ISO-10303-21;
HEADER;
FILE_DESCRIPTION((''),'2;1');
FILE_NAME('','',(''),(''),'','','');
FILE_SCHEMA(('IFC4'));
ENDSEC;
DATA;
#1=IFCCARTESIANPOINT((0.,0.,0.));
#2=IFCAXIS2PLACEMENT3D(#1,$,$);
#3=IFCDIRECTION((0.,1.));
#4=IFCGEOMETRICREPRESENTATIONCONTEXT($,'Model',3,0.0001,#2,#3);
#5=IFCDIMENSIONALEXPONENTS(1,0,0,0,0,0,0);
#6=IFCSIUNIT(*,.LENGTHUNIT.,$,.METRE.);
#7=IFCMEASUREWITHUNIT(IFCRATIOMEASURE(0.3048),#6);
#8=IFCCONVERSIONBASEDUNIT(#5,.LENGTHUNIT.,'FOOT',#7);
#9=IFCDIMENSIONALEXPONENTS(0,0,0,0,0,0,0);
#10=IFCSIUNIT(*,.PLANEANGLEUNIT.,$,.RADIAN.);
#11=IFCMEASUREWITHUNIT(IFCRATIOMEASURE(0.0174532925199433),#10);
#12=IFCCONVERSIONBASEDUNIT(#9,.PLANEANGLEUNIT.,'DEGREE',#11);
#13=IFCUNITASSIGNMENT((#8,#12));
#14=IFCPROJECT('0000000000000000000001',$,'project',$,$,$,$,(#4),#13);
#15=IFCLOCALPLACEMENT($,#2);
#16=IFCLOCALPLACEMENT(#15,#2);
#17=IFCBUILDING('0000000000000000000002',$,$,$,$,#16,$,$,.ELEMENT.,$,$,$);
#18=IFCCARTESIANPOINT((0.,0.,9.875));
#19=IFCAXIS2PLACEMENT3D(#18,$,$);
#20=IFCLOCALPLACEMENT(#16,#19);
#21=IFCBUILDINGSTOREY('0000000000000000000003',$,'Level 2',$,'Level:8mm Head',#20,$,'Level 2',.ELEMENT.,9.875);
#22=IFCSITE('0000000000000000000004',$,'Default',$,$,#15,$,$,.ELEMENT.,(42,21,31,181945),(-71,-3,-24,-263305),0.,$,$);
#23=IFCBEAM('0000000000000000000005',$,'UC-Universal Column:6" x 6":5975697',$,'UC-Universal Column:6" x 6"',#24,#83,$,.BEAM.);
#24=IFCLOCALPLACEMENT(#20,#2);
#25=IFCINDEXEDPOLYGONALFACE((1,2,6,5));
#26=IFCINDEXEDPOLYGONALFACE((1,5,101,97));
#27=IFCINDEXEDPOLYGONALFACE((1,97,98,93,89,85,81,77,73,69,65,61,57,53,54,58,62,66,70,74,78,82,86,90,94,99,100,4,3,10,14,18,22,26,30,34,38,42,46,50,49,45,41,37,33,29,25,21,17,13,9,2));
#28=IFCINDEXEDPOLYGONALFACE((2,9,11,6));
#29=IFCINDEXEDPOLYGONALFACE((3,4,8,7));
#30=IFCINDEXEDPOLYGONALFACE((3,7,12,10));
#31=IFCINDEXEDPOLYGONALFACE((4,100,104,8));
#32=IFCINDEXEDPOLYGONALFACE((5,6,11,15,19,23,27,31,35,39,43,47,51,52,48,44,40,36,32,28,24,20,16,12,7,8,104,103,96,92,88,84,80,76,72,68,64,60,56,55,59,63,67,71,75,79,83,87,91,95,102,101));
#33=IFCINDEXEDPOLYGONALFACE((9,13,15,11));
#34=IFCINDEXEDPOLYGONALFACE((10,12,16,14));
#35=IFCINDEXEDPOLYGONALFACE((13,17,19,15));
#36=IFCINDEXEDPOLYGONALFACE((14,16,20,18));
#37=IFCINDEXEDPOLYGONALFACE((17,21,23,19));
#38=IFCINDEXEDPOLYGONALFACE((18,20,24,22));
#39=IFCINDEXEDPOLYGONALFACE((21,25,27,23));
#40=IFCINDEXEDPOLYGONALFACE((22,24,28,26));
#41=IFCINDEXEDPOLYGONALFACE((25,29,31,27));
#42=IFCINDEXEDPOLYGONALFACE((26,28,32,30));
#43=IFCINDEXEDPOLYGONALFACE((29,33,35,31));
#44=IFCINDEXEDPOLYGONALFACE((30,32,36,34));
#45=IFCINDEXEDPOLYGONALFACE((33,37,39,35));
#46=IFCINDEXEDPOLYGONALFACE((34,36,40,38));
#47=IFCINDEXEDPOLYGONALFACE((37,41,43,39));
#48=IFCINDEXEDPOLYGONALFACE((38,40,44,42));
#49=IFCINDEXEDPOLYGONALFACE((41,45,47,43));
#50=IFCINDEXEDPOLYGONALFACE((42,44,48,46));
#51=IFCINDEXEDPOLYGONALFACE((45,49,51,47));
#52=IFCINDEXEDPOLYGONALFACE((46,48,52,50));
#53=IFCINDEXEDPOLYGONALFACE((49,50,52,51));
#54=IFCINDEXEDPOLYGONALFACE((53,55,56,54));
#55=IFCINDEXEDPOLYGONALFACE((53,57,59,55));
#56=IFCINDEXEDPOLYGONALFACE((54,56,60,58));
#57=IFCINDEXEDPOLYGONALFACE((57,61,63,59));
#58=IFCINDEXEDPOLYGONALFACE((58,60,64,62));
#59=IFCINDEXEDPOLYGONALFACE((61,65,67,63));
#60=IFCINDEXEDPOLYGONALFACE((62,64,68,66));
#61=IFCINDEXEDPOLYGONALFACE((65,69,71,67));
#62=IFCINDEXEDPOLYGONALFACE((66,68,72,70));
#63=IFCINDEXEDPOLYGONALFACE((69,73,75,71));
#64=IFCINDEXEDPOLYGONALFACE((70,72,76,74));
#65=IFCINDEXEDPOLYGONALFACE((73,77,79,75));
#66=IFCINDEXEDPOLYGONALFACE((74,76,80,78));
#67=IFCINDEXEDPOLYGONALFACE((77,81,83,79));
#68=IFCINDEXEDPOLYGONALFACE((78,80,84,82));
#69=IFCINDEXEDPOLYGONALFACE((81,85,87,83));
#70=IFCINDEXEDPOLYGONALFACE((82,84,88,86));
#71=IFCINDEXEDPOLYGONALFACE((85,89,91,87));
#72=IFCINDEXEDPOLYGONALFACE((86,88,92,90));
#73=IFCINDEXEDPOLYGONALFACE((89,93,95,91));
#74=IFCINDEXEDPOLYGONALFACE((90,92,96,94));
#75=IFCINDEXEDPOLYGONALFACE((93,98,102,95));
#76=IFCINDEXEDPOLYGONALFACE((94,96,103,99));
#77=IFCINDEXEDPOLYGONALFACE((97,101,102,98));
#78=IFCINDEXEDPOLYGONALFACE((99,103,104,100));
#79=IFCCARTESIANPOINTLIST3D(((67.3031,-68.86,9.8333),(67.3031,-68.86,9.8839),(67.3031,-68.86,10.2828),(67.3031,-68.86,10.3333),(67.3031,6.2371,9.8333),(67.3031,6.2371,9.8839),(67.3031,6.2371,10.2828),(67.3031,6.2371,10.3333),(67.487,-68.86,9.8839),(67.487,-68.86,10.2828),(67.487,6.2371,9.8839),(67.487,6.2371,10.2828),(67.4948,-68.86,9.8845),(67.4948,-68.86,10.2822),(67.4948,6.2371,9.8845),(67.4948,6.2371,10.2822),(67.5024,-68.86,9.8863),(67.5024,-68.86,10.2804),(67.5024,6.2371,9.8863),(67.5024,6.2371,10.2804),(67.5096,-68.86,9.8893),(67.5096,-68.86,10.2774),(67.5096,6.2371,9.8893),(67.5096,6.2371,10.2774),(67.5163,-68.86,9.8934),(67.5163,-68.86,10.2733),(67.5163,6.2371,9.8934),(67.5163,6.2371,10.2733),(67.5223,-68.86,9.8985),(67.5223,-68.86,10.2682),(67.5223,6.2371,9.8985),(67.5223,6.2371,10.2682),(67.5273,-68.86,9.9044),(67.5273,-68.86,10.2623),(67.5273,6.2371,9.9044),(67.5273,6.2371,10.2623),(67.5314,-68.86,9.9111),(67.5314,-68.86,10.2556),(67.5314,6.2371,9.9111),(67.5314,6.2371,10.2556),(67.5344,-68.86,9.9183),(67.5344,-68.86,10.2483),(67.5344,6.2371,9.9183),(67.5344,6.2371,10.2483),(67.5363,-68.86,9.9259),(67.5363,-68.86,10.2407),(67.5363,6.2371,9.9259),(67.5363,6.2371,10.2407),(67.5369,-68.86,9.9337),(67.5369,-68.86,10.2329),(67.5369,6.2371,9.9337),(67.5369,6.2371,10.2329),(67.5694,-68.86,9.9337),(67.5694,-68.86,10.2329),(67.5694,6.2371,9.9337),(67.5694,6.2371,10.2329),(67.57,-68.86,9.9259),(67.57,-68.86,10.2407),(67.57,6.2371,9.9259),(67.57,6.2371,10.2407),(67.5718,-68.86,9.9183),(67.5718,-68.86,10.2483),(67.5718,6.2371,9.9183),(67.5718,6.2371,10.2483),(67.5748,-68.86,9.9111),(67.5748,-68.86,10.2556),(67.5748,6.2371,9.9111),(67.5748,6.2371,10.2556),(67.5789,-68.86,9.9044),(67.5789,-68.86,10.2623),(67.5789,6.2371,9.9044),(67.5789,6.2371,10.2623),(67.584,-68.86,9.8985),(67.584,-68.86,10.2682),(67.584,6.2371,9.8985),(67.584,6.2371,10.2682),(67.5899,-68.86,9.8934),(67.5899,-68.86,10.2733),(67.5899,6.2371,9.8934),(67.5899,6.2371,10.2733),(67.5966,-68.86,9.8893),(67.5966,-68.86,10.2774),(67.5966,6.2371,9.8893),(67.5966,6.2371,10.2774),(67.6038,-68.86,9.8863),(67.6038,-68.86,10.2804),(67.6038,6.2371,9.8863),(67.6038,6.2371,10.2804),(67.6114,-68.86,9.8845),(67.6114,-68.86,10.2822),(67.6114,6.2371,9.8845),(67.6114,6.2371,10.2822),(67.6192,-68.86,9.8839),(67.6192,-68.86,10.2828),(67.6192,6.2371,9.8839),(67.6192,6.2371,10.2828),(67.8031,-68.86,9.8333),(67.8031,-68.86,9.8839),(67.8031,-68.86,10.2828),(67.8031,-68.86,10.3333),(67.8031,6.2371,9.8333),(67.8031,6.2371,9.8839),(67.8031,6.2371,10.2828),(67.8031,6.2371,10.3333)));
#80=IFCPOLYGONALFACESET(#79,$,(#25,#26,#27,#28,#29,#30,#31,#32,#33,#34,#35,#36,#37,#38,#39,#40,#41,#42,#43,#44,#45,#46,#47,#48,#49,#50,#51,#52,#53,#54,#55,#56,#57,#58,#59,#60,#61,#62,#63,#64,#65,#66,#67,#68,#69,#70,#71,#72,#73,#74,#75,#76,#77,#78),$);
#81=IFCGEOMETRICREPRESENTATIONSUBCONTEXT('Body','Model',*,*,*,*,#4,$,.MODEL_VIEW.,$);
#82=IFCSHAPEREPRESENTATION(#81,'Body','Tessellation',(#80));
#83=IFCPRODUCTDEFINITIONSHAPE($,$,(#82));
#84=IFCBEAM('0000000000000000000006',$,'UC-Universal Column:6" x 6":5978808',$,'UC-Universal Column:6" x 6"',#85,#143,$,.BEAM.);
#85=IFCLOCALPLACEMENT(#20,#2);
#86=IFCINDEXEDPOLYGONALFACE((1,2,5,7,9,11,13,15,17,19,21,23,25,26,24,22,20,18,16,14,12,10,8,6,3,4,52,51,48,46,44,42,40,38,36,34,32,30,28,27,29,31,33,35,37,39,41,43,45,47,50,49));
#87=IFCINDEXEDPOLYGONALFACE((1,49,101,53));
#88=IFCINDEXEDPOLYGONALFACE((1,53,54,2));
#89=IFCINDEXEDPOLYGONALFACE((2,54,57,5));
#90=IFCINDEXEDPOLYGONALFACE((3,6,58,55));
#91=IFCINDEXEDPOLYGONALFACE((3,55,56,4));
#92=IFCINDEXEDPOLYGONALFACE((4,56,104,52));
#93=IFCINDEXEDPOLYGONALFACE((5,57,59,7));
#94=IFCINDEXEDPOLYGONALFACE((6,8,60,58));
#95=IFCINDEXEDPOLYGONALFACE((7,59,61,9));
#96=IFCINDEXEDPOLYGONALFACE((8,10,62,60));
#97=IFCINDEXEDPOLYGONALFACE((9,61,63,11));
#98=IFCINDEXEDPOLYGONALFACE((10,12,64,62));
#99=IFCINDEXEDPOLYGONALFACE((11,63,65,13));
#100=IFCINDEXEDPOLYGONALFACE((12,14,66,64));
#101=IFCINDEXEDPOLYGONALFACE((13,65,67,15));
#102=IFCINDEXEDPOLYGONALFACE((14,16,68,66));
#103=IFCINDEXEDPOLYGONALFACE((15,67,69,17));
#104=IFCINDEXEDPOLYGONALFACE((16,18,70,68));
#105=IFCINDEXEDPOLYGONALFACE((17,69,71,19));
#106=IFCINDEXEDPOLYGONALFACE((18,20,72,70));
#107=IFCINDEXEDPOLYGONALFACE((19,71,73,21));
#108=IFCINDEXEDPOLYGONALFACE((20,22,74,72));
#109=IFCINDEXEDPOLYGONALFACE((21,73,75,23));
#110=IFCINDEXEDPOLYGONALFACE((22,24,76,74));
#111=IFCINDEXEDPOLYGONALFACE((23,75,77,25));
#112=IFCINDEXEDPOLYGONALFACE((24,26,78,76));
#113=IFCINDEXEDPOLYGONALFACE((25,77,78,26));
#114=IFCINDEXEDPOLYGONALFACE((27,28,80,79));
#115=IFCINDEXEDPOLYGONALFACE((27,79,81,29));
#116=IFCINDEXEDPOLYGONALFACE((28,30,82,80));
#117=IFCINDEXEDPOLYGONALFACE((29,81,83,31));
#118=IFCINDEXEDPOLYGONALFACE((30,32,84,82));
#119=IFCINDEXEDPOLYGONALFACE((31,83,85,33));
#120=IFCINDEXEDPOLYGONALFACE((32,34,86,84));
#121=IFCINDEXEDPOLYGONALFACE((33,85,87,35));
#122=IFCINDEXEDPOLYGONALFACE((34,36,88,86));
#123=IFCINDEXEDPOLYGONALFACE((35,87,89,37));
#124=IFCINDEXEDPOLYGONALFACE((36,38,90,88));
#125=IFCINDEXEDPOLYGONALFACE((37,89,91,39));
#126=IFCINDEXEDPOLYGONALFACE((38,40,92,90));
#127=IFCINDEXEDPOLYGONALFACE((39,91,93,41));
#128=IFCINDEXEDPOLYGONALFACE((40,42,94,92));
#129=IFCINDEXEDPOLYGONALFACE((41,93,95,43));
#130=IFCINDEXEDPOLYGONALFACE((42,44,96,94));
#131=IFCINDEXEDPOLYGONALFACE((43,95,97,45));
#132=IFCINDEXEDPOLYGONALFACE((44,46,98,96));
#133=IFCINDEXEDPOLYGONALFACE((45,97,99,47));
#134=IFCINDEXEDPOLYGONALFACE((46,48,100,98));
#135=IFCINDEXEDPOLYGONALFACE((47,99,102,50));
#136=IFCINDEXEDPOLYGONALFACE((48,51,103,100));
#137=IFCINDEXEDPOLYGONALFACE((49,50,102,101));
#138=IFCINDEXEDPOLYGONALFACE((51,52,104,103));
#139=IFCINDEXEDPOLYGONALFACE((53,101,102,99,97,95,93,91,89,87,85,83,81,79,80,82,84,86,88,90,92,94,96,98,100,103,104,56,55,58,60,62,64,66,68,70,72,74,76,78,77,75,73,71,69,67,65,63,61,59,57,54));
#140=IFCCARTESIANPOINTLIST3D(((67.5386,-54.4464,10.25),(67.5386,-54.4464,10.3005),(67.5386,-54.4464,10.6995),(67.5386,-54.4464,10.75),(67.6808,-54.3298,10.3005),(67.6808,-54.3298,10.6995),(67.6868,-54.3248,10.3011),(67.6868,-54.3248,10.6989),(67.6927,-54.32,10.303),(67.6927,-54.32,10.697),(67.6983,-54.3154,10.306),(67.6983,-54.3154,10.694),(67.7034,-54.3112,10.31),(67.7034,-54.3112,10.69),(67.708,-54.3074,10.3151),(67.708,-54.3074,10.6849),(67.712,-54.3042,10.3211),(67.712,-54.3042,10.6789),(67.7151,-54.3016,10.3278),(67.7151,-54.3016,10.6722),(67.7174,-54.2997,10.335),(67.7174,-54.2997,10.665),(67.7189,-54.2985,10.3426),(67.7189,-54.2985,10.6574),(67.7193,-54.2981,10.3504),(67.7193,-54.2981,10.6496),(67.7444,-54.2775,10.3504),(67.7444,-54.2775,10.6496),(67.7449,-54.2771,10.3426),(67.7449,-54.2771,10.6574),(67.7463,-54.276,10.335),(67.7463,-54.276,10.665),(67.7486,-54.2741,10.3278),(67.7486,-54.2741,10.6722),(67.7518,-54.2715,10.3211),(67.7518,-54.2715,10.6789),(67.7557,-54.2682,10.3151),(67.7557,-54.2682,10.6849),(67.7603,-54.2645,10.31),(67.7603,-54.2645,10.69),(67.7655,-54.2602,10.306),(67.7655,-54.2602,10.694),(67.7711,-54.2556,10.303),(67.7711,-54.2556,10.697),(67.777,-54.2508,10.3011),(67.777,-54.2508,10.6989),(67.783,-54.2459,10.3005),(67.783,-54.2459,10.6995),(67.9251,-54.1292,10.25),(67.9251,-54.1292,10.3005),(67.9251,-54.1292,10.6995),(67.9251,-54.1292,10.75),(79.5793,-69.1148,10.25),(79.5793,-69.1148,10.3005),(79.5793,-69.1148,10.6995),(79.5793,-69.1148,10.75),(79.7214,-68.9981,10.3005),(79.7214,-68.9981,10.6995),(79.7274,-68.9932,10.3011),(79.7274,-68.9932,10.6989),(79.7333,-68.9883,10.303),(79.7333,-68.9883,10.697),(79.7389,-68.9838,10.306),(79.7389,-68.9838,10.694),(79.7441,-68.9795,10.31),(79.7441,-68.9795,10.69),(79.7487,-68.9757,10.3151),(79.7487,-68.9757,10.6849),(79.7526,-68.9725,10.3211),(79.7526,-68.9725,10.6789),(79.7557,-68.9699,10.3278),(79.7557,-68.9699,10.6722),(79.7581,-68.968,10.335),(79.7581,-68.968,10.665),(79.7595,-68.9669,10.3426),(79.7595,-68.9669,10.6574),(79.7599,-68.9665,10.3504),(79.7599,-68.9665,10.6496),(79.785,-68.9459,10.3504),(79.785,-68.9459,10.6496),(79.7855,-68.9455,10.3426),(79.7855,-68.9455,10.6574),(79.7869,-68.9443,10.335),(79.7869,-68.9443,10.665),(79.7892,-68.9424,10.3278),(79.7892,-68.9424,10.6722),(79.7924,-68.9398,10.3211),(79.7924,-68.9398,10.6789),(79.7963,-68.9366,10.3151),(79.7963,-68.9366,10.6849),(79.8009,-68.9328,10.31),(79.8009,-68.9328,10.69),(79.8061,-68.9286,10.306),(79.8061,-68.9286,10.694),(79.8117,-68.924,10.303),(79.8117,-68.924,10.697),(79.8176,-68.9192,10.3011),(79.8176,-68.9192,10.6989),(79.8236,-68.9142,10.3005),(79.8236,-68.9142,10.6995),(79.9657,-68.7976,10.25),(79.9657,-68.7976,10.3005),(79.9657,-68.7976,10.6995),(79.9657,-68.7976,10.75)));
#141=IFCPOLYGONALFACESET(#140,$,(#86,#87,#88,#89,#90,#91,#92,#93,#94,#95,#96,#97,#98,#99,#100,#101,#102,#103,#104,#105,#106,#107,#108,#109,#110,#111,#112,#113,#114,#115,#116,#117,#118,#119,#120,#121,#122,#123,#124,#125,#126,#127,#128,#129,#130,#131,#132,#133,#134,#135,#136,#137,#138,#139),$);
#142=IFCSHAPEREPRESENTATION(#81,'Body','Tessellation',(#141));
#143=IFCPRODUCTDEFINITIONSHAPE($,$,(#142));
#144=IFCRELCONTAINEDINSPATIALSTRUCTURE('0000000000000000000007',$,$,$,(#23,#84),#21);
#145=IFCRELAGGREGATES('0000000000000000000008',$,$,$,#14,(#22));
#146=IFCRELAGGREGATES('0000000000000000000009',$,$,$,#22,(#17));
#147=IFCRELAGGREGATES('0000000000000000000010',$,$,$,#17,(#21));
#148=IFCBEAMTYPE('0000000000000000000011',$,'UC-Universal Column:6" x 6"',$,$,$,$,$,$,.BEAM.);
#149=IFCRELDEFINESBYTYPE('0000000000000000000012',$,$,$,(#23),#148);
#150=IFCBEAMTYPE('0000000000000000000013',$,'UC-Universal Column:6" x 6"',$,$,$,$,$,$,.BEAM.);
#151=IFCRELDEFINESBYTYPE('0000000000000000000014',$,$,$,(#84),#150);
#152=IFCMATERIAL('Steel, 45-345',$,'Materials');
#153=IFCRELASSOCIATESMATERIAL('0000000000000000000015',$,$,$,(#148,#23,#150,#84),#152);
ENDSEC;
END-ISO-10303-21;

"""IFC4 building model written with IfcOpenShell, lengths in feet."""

from ifc_helpers import new_model, entity, si_unit, converted_unit, direction, frame, origin, place, context, subcontext, project, spatial, indexed_curve, outline, extrude, source, transform, mapped, material, type_object, type_shapes, element, save


model = new_model("IFC4")

# Units and contexts
model_context = context("Model", 3, precision=0.0001, world=origin(), true_north=direction((0.0, 1.0)))
body_context = subcontext(model_context, "Body", "Model", "MODEL_VIEW")
ifc_project = project(units=[converted_unit("LENGTHUNIT", "FOOT", entity("IfcRatioMeasure", 0.3048), si_unit("LENGTHUNIT", "METRE"), dimensions=[1, 0, 0, 0, 0, 0, 0]), converted_unit("PLANEANGLEUNIT", "DEGREE", entity("IfcRatioMeasure", 0.0174532925199433), si_unit("PLANEANGLEUNIT", "RADIAN"), dimensions=[0, 0, 0, 0, 0, 0, 0])], contexts=[model_context])

# Site, building, storey
site_placement = place(None, origin())
site = spatial("IfcSite", under=ifc_project, at=site_placement, Name="Default", CompositionType="ELEMENT", RefLatitude=(42, 21, 31, 181945), RefLongitude=(-71, -3, -24, -263305), RefElevation=0.0)
building_placement = place(site_placement, origin())
building = spatial("IfcBuilding", under=site, at=building_placement, CompositionType="ELEMENT")
storey_placement = place(building_placement, frame((0.0, 0.0, 9.875)))
storey = spatial("IfcBuildingStorey", under=building, at=storey_placement, Name="Level 2", ObjectType="Level:8mm Head", LongName="Level 2", CompositionType="ELEMENT", Elevation=9.875)

# Beams
ifc_material_1 = material(Name="Steel, 45-345", Category="Materials")
beam_type_1 = type_object("IfcBeamType", Name="UC-Universal Column:6\" x 6\"", PredefinedType="BEAM", material=ifc_material_1)
shared_shape_1 = source(origin(), body_context, "Body", "SweptSolid", [
    extrude(outline(indexed_curve([(-0.25, -0.25), (-0.1995, -0.25), (-0.1995, -0.0661), (-0.1989, -0.0583), (-0.197, -0.0507), (-0.194, -0.0435), (-0.19, -0.0368), (-0.1849, -0.0308), (-0.1789, -0.0258), (-0.1722, -0.0217), (-0.165, -0.0187), (-0.1574, -0.0169), (-0.1496, -0.0162), (0.1496, -0.0162), (0.1574, -0.0169), (0.165, -0.0187), (0.1722, -0.0217), (0.1789, -0.0258), (0.1849, -0.0308), (0.19, -0.0368), (0.194, -0.0435), (0.197, -0.0507), (0.1989, -0.0583), (0.1995, -0.0661), (0.1995, -0.25), (0.25, -0.25), (0.25, 0.25), (0.1995, 0.25), (0.1995, 0.0661), (0.1989, 0.0583), (0.197, 0.0507), (0.194, 0.0435), (0.19, 0.0368), (0.1849, 0.0308), (0.1789, 0.0258), (0.1722, 0.0217), (0.165, 0.0187), (0.1574, 0.0169), (0.1496, 0.0162), (-0.1496, 0.0162), (-0.1574, 0.0169), (-0.165, 0.0187), (-0.1722, 0.0217), (-0.1789, 0.0258), (-0.1849, 0.0308), (-0.19, 0.0368), (-0.194, 0.0435), (-0.197, 0.0507), (-0.1989, 0.0583), (-0.1995, 0.0661), (-0.1995, 0.25), (-0.25, 0.25), (-0.25, -0.25)], self_intersect=False)), frame((-7.7826, 0.0, 0.0), z_axis=(1.0, 0.0, 0.0), x_axis=(0.0, 0.0, -1.0)), (0.0, 0.0, 1.0), 75.0972),
])
type_shapes(beam_type_1, [shared_shape_1])
beam_1_placement = place(storey_placement, frame((67.5531, -61.0774, 10.0833), z_axis=(0.0, 0.0, 1.0), x_axis=(0.0, 1.0, 0.0)))
element("IfcBeam", 1, at=beam_1_placement, inside=storey, type_object=beam_type_1, material=ifc_material_1, Name="UC-Universal Column:6\" x 6\":5975697", ObjectType="UC-Universal Column:6\" x 6\"", PredefinedType="BEAM", context=body_context, shape_type="MappedRepresentation", body=[
    mapped(shared_shape_1, transform((0.0, 0.0, 0.0), scale=1.0)),
])
beam_type_2 = type_object("IfcBeamType", Name="UC-Universal Column:6\" x 6\"", PredefinedType="BEAM", material=ifc_material_1)
shared_shape_2 = source(origin(), body_context, "Body", "SweptSolid", [
    extrude(outline(indexed_curve([(-0.25, -0.25), (-0.1995, -0.25), (-0.1995, -0.0661), (-0.1989, -0.0583), (-0.197, -0.0507), (-0.194, -0.0435), (-0.19, -0.0368), (-0.1849, -0.0308), (-0.1789, -0.0258), (-0.1722, -0.0217), (-0.165, -0.0187), (-0.1574, -0.0169), (-0.1496, -0.0162), (0.1496, -0.0162), (0.1574, -0.0169), (0.165, -0.0187), (0.1722, -0.0217), (0.1789, -0.0258), (0.1849, -0.0308), (0.19, -0.0368), (0.194, -0.0435), (0.197, -0.0507), (0.1989, -0.0583), (0.1995, -0.0661), (0.1995, -0.25), (0.25, -0.25), (0.25, 0.25), (0.1995, 0.25), (0.1995, 0.0661), (0.1989, 0.0583), (0.197, 0.0507), (0.194, 0.0435), (0.19, 0.0368), (0.1849, 0.0308), (0.1789, 0.0258), (0.1722, 0.0217), (0.165, 0.0187), (0.1574, 0.0169), (0.1496, 0.0162), (-0.1496, 0.0162), (-0.1574, 0.0169), (-0.165, 0.0187), (-0.1722, 0.0217), (-0.1789, 0.0258), (-0.1849, 0.0308), (-0.19, 0.0368), (-0.194, 0.0435), (-0.197, 0.0507), (-0.1989, 0.0583), (-0.1995, 0.0661), (-0.1995, 0.25), (-0.25, 0.25), (-0.25, -0.25)], self_intersect=False)), frame((-9.2456, 0.0, 0.0), z_axis=(1.0, 0.0, 0.0), x_axis=(0.0, 0.0, -1.0)), (0.0, 0.0, 1.0), 18.9773),
])
type_shapes(beam_type_2, [shared_shape_2])
beam_2_placement = place(storey_placement, frame((73.598, -61.4341, 10.5), z_axis=(0.0, 0.0, 1.0), x_axis=(0.634475, -0.772943, 0.0)))
element("IfcBeam", 2, at=beam_2_placement, inside=storey, type_object=beam_type_2, material=ifc_material_1, Name="UC-Universal Column:6\" x 6\":5978808", ObjectType="UC-Universal Column:6\" x 6\"", PredefinedType="BEAM", context=body_context, shape_type="MappedRepresentation", body=[
    mapped(shared_shape_2, transform((0.0, 0.0, 0.0), scale=1.0)),
])

save(model, "model.ifc")
